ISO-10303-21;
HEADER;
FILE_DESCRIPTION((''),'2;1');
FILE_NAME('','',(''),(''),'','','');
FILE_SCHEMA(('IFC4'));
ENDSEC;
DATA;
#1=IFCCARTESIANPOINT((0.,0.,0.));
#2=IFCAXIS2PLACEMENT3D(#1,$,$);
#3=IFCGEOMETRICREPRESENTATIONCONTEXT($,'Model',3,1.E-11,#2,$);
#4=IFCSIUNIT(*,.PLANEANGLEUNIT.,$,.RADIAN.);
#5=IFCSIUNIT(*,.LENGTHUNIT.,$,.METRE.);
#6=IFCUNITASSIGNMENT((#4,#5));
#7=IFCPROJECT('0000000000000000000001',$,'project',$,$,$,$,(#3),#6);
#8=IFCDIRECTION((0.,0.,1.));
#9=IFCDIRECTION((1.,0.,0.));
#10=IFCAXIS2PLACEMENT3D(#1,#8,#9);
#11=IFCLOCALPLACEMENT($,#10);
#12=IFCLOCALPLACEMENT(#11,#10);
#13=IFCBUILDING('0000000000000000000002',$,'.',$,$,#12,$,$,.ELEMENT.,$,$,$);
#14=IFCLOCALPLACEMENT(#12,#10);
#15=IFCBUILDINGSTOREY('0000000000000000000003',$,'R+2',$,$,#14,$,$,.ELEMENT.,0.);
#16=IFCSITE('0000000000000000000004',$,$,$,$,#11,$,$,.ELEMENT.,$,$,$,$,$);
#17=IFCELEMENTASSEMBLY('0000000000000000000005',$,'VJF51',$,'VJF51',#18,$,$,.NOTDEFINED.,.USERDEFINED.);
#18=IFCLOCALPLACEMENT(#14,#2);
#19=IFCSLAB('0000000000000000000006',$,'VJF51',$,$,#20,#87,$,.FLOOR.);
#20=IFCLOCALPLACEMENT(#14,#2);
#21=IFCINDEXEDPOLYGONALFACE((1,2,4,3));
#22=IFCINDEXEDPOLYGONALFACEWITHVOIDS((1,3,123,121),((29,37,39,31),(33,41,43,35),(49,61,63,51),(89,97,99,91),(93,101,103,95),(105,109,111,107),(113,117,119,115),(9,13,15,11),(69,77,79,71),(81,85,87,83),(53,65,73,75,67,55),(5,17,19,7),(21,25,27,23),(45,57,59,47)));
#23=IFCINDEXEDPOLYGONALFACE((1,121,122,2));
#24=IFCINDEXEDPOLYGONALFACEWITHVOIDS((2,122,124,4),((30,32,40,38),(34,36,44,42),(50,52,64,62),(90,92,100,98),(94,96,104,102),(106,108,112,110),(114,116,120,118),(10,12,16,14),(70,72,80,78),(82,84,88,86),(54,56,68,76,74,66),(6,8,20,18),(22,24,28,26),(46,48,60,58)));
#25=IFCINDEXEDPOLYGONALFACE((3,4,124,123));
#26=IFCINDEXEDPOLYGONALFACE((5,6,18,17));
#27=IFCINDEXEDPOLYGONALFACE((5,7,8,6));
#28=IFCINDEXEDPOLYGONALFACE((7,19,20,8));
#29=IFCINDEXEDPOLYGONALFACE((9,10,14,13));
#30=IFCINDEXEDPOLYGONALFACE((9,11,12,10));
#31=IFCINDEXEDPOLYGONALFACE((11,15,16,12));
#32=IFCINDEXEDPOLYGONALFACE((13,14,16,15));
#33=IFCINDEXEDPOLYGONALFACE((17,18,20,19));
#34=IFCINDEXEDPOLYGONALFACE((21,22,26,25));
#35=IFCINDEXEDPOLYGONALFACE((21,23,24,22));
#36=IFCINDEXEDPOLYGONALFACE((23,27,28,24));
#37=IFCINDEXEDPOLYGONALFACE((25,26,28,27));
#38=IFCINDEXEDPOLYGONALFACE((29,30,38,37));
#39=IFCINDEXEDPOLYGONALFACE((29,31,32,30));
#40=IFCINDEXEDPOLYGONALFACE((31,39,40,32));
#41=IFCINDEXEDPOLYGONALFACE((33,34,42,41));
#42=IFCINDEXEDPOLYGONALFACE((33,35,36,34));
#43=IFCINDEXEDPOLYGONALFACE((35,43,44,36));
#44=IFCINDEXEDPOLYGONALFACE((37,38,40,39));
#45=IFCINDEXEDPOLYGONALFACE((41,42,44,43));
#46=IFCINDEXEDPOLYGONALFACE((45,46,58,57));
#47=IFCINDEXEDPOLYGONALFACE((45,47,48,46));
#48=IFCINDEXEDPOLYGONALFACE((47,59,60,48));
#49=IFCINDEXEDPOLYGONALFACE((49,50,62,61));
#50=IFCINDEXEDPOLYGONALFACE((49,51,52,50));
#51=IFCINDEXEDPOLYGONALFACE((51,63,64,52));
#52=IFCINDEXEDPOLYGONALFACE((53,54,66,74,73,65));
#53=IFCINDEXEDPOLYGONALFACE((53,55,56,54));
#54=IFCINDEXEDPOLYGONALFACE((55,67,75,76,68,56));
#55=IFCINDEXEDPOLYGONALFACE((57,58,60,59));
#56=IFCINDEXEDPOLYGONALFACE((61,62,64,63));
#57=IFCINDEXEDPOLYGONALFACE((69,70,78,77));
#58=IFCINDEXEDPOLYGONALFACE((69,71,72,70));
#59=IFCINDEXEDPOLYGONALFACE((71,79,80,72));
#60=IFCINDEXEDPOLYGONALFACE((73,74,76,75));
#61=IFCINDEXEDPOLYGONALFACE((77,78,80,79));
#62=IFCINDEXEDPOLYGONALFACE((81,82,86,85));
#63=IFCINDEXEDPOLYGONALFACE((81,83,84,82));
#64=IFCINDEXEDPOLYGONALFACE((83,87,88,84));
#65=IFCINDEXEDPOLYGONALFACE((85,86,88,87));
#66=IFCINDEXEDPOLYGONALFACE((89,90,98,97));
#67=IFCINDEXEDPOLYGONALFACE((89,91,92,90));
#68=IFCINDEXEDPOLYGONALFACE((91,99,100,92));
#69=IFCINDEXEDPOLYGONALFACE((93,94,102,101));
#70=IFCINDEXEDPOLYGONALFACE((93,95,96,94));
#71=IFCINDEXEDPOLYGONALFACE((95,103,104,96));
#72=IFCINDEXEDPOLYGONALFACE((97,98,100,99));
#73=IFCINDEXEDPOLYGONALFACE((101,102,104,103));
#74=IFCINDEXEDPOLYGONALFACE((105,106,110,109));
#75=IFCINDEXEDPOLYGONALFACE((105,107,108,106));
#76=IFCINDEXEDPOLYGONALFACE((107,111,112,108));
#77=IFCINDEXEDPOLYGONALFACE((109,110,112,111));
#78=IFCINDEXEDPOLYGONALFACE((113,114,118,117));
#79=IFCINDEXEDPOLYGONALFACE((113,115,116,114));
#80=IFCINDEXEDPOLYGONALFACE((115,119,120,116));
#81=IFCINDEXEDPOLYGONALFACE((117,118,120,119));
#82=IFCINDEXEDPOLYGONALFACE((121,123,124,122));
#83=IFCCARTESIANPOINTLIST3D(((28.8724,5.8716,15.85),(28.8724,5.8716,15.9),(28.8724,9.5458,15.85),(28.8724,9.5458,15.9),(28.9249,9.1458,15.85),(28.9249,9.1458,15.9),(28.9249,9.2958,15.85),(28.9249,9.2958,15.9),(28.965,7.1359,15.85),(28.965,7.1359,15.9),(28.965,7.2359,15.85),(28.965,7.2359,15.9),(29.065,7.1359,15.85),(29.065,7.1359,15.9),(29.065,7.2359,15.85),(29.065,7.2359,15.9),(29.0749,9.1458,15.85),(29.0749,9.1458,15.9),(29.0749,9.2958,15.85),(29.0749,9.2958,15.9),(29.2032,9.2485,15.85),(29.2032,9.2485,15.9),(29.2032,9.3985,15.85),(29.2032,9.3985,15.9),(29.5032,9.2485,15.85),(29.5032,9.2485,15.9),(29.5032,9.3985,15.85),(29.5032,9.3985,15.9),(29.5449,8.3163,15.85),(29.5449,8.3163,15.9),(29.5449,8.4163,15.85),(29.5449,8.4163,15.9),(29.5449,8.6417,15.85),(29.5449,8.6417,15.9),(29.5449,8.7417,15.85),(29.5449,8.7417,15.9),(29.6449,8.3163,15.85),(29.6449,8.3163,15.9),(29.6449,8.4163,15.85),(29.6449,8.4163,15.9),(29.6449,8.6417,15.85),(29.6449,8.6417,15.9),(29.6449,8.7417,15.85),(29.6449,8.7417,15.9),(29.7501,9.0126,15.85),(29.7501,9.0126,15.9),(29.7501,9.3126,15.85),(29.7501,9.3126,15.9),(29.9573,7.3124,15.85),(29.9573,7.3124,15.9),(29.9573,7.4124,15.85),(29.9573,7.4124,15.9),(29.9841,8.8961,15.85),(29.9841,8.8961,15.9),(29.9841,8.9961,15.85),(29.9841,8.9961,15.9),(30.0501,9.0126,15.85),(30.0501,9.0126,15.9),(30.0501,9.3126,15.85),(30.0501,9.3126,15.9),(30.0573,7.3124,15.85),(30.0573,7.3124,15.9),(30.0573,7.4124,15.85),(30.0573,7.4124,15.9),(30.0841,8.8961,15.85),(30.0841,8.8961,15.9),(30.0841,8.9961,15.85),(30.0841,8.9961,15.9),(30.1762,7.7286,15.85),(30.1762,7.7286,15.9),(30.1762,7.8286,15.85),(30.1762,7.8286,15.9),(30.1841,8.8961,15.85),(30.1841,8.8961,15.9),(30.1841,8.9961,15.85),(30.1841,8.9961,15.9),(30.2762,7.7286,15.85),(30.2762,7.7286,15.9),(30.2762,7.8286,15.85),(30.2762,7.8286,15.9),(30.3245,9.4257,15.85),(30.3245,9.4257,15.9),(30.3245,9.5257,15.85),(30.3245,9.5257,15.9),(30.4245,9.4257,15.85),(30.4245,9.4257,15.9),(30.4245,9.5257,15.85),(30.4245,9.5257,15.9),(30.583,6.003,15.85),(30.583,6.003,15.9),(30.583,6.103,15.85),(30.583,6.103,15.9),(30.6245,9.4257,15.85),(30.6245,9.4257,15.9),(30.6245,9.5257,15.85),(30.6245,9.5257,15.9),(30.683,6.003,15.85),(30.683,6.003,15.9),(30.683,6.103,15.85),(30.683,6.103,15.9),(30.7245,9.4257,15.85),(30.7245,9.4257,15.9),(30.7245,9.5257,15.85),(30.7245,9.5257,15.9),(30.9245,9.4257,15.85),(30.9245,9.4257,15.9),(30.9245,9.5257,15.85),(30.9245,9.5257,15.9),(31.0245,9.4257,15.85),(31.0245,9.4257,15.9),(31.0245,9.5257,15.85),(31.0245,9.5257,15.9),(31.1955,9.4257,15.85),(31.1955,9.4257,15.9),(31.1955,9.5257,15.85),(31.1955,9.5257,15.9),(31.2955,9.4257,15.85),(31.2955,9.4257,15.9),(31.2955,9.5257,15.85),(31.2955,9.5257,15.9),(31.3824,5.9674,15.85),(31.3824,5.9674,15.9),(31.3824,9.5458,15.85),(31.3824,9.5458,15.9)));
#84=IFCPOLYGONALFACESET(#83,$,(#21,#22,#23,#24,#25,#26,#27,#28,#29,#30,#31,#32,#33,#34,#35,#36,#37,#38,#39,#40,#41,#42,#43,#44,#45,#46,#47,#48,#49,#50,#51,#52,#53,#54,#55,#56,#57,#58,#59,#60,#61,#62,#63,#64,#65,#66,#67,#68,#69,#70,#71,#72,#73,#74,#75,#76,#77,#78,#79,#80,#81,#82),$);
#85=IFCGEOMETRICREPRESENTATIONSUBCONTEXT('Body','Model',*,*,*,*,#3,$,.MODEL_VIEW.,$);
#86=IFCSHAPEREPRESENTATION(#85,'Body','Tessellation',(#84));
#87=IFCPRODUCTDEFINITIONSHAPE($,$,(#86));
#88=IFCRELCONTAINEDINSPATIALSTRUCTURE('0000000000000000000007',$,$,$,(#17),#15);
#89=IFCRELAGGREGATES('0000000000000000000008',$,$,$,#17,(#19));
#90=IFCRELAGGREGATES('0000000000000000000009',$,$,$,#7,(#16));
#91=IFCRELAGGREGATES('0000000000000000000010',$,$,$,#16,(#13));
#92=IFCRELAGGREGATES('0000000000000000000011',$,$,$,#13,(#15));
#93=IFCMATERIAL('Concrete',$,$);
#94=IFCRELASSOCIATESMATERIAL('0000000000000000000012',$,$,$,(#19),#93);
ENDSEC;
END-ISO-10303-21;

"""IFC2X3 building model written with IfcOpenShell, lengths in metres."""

from ifc_helpers import new_model, si_unit, frame, origin, origin_with_axes, place, context, subcontext, project, spatial, polyline, outline, extrude, material, element, aggregate, save


model = new_model("IFC2X3")

# Units and contexts
model_context = context("Model", 3, precision=1e-11, world=origin())
body_context = subcontext(model_context, "Body", "Model", "MODEL_VIEW")
ifc_project = project(units=[si_unit("PLANEANGLEUNIT", "RADIAN"), si_unit("LENGTHUNIT", "METRE")], contexts=[model_context])

# Site, building, storey
site_placement = place(None, origin_with_axes())
site = spatial("IfcSite", under=ifc_project, at=site_placement, CompositionType="ELEMENT")
building_placement = place(site_placement, origin_with_axes())
building = spatial("IfcBuilding", under=site, at=building_placement, Name=".", CompositionType="ELEMENT")
storey_placement = place(building_placement, origin_with_axes())
storey = spatial("IfcBuildingStorey", under=building, at=storey_placement, Name="R+2", CompositionType="ELEMENT", Elevation=0.0)

# Element assembly, slab, openings
ifc_material = material(Name="Concrete")
assembly_1_placement = place(storey_placement, origin_with_axes())
assembly_1 = element("IfcElementAssembly", 1, at=assembly_1_placement, inside=storey, Name="VJF51", ObjectType="VJF51", AssemblyPlace="NOTDEFINED", PredefinedType="USERDEFINED")
slab_1_placement = place(assembly_1_placement, frame((31.3824, 5.8716, 15.85), z_axis=(0.0, 0.0, 1.0), x_axis=(0.0, 1.0, 0.0)))
slab_1 = element("IfcSlab", 2, at=slab_1_placement, material=ifc_material, Name="VJF51", PredefinedType="FLOOR", context=body_context, shape_type="SweptSolid", body=[
    extrude(outline(polyline([(0.0, -0.0958), (0.0, -3.6742), (2.51, -3.6742), (2.51, 0.0), (0.0, -0.0958)])), frame((0.0, 0.0, 0.0), z_axis=(0.0, 0.0, 1.0), x_axis=(0.0, 1.0, 0.0)), (0.0, 0.0, 1.0), 0.05),
])
opening_1_placement = place(slab_1_placement, origin_with_axes())
element("IfcOpeningElement", 3, at=opening_1_placement, cuts=slab_1, ObjectType="Opening", context=body_context, shape_type="SweptSolid", body=[
    extrude(outline(polyline([(2.3075, -3.2742), (2.3075, -3.4242), (2.4575, -3.4242), (2.4575, -3.2742), (2.3075, -3.2742)])), frame((0.0, 0.0, 0.0), z_axis=(0.0, 0.0, 1.0), x_axis=(0.0, 1.0, 0.0)), (0.0, 0.0, 1.0), 0.05),
])
opening_2_placement = place(slab_1_placement, origin_with_axes())
element("IfcOpeningElement", 4, at=opening_2_placement, cuts=slab_1, ObjectType="Opening", context=body_context, shape_type="SweptSolid", body=[
    extrude(outline(polyline([(1.3323, -3.141), (1.3323, -3.441), (1.6323, -3.441), (1.6323, -3.141), (1.3323, -3.141)])), frame((0.0, 0.0, 0.0), z_axis=(0.0, 0.0, 1.0), x_axis=(0.0, 1.0, 0.0)), (0.0, 0.0, 1.0), 0.05),
])
opening_3_placement = place(slab_1_placement, origin_with_axes())
element("IfcOpeningElement", 5, at=opening_3_placement, cuts=slab_1, ObjectType="Opening", context=body_context, shape_type="SweptSolid", body=[
    extrude(outline(polyline([(1.8792, -3.3769), (1.8792, -3.5269), (2.1792, -3.5269), (2.1792, -3.3769), (1.8792, -3.3769)])), frame((0.0, 0.0, 0.0), z_axis=(0.0, 0.0, 1.0), x_axis=(0.0, 1.0, 0.0)), (0.0, 0.0, 1.0), 0.05),
])
opening_4_placement = place(slab_1_placement, origin_with_axes())
element("IfcOpeningElement", 6, at=opening_4_placement, cuts=slab_1, ObjectType="Opening", context=body_context, shape_type="SweptSolid", body=[
    extrude(outline(polyline([(1.1983, -3.0245), (1.1983, -3.1245), (1.2983, -3.1245), (1.2983, -3.0245), (1.1983, -3.0245)])), frame((0.0, 0.0, 0.0), z_axis=(0.0, 0.0, 1.0), x_axis=(0.0, 1.0, 0.0)), (0.0, 0.0, 1.0), 0.05),
])
opening_5_placement = place(slab_1_placement, origin_with_axes())
element("IfcOpeningElement", 7, at=opening_5_placement, cuts=slab_1, ObjectType="Opening", context=body_context, shape_type="SweptSolid", body=[
    extrude(outline(polyline([(1.2983, -3.0245), (1.2983, -3.1245), (1.3983, -3.1245), (1.3983, -3.0245), (1.2983, -3.0245)])), frame((0.0, 0.0, 0.0), z_axis=(0.0, 0.0, 1.0), x_axis=(0.0, 1.0, 0.0)), (0.0, 0.0, 1.0), 0.05),
])
opening_6_placement = place(slab_1_placement, origin_with_axes())
element("IfcOpeningElement", 8, at=opening_6_placement, cuts=slab_1, ObjectType="Opening", context=body_context, shape_type="SweptSolid", body=[
    extrude(outline(polyline([(0.6994, -0.1314), (0.6994, -0.2314), (0.7994, -0.2314), (0.7994, -0.1314), (0.6994, -0.1314)])), frame((0.0, 0.0, 0.0), z_axis=(0.0, 0.0, 1.0), x_axis=(0.0, 1.0, 0.0)), (0.0, 0.0, 1.0), 0.05),
])
opening_7_placement = place(slab_1_placement, origin_with_axes())
element("IfcOpeningElement", 9, at=opening_7_placement, cuts=slab_1, ObjectType="Opening", context=body_context, shape_type="SweptSolid", body=[
    extrude(outline(polyline([(1.1062, -1.857), (1.1062, -1.957), (1.2062, -1.957), (1.2062, -1.857), (1.1062, -1.857)])), frame((0.0, 0.0, 0.0), z_axis=(0.0, 0.0, 1.0), x_axis=(0.0, 1.0, 0.0)), (0.0, 0.0, 1.0), 0.05),
])
opening_8_placement = place(slab_1_placement, origin_with_axes())
element("IfcOpeningElement", 10, at=opening_8_placement, cuts=slab_1, ObjectType="Opening", context=body_context, shape_type="SweptSolid", body=[
    extrude(outline(polyline([(1.3252, -1.4408), (1.3252, -1.5408), (1.4252, -1.5408), (1.4252, -1.4408), (1.3252, -1.4408)])), frame((0.0, 0.0, 0.0), z_axis=(0.0, 0.0, 1.0), x_axis=(0.0, 1.0, 0.0)), (0.0, 0.0, 1.0), 0.05),
])
opening_9_placement = place(slab_1_placement, origin_with_axes())
element("IfcOpeningElement", 11, at=opening_9_placement, cuts=slab_1, ObjectType="Opening", context=body_context, shape_type="SweptSolid", body=[
    extrude(outline(polyline([(2.3174, -1.2643), (2.3174, -1.3643), (2.4174, -1.3643), (2.4174, -1.2643), (2.3174, -1.2643)])), frame((0.0, 0.0, 0.0), z_axis=(0.0, 0.0, 1.0), x_axis=(0.0, 1.0, 0.0)), (0.0, 0.0, 1.0), 0.05),
])
opening_10_placement = place(slab_1_placement, origin_with_axes())
element("IfcOpeningElement", 12, at=opening_10_placement, cuts=slab_1, ObjectType="Opening", context=body_context, shape_type="SweptSolid", body=[
    extrude(outline(polyline([(1.7375, -2.4448), (1.7375, -2.5448), (1.8375, -2.5448), (1.8375, -2.4448), (1.7375, -2.4448)])), frame((0.0, 0.0, 0.0), z_axis=(0.0, 0.0, 1.0), x_axis=(0.0, 1.0, 0.0)), (0.0, 0.0, 1.0), 0.05),
])
opening_11_placement = place(slab_1_placement, origin_with_axes())
element("IfcOpeningElement", 13, at=opening_11_placement, cuts=slab_1, ObjectType="Opening", context=body_context, shape_type="SweptSolid", body=[
    extrude(outline(polyline([(1.7375, -2.7702), (1.7375, -2.8702), (1.8375, -2.8702), (1.8375, -2.7702), (1.7375, -2.7702)])), frame((0.0, 0.0, 0.0), z_axis=(0.0, 0.0, 1.0), x_axis=(0.0, 1.0, 0.0)), (0.0, 0.0, 1.0), 0.05),
])
opening_12_placement = place(slab_1_placement, origin_with_axes())
element("IfcOpeningElement", 14, at=opening_12_placement, cuts=slab_1, ObjectType="Opening", context=body_context, shape_type="SweptSolid", body=[
    extrude(outline(polyline([(0.0869, -3.5541), (0.0869, -3.6541), (0.1869, -3.6541), (0.1869, -3.5541), (0.0869, -3.5541)])), frame((0.0, 0.0, 0.0), z_axis=(0.0, 0.0, 1.0), x_axis=(0.0, 1.0, 0.0)), (0.0, 0.0, 1.0), 0.05),
])
opening_13_placement = place(slab_1_placement, origin_with_axes())
element("IfcOpeningElement", 15, at=opening_13_placement, cuts=slab_1, ObjectType="Opening", context=body_context, shape_type="SweptSolid", body=[
    extrude(outline(polyline([(0.3579, -3.5541), (0.3579, -3.6541), (0.4579, -3.6541), (0.4579, -3.5541), (0.3579, -3.5541)])), frame((0.0, 0.0, 0.0), z_axis=(0.0, 0.0, 1.0), x_axis=(0.0, 1.0, 0.0)), (0.0, 0.0, 1.0), 0.05),
])
opening_14_placement = place(slab_1_placement, origin_with_axes())
element("IfcOpeningElement", 16, at=opening_14_placement, cuts=slab_1, ObjectType="Opening", context=body_context, shape_type="SweptSolid", body=[
    extrude(outline(polyline([(0.6579, -3.5541), (0.6579, -3.6541), (0.7579, -3.6541), (0.7579, -3.5541), (0.6579, -3.5541)])), frame((0.0, 0.0, 0.0), z_axis=(0.0, 0.0, 1.0), x_axis=(0.0, 1.0, 0.0)), (0.0, 0.0, 1.0), 0.05),
])
opening_15_placement = place(slab_1_placement, origin_with_axes())
element("IfcOpeningElement", 17, at=opening_15_placement, cuts=slab_1, ObjectType="Opening", context=body_context, shape_type="SweptSolid", body=[
    extrude(outline(polyline([(0.958, -3.5541), (0.958, -3.6541), (1.058, -3.6541), (1.058, -3.5541), (0.958, -3.5541)])), frame((0.0, 0.0, 0.0), z_axis=(0.0, 0.0, 1.0), x_axis=(0.0, 1.0, 0.0)), (0.0, 0.0, 1.0), 0.05),
])

aggregate(assembly_1, [slab_1])

save(model, "model.ifc")
